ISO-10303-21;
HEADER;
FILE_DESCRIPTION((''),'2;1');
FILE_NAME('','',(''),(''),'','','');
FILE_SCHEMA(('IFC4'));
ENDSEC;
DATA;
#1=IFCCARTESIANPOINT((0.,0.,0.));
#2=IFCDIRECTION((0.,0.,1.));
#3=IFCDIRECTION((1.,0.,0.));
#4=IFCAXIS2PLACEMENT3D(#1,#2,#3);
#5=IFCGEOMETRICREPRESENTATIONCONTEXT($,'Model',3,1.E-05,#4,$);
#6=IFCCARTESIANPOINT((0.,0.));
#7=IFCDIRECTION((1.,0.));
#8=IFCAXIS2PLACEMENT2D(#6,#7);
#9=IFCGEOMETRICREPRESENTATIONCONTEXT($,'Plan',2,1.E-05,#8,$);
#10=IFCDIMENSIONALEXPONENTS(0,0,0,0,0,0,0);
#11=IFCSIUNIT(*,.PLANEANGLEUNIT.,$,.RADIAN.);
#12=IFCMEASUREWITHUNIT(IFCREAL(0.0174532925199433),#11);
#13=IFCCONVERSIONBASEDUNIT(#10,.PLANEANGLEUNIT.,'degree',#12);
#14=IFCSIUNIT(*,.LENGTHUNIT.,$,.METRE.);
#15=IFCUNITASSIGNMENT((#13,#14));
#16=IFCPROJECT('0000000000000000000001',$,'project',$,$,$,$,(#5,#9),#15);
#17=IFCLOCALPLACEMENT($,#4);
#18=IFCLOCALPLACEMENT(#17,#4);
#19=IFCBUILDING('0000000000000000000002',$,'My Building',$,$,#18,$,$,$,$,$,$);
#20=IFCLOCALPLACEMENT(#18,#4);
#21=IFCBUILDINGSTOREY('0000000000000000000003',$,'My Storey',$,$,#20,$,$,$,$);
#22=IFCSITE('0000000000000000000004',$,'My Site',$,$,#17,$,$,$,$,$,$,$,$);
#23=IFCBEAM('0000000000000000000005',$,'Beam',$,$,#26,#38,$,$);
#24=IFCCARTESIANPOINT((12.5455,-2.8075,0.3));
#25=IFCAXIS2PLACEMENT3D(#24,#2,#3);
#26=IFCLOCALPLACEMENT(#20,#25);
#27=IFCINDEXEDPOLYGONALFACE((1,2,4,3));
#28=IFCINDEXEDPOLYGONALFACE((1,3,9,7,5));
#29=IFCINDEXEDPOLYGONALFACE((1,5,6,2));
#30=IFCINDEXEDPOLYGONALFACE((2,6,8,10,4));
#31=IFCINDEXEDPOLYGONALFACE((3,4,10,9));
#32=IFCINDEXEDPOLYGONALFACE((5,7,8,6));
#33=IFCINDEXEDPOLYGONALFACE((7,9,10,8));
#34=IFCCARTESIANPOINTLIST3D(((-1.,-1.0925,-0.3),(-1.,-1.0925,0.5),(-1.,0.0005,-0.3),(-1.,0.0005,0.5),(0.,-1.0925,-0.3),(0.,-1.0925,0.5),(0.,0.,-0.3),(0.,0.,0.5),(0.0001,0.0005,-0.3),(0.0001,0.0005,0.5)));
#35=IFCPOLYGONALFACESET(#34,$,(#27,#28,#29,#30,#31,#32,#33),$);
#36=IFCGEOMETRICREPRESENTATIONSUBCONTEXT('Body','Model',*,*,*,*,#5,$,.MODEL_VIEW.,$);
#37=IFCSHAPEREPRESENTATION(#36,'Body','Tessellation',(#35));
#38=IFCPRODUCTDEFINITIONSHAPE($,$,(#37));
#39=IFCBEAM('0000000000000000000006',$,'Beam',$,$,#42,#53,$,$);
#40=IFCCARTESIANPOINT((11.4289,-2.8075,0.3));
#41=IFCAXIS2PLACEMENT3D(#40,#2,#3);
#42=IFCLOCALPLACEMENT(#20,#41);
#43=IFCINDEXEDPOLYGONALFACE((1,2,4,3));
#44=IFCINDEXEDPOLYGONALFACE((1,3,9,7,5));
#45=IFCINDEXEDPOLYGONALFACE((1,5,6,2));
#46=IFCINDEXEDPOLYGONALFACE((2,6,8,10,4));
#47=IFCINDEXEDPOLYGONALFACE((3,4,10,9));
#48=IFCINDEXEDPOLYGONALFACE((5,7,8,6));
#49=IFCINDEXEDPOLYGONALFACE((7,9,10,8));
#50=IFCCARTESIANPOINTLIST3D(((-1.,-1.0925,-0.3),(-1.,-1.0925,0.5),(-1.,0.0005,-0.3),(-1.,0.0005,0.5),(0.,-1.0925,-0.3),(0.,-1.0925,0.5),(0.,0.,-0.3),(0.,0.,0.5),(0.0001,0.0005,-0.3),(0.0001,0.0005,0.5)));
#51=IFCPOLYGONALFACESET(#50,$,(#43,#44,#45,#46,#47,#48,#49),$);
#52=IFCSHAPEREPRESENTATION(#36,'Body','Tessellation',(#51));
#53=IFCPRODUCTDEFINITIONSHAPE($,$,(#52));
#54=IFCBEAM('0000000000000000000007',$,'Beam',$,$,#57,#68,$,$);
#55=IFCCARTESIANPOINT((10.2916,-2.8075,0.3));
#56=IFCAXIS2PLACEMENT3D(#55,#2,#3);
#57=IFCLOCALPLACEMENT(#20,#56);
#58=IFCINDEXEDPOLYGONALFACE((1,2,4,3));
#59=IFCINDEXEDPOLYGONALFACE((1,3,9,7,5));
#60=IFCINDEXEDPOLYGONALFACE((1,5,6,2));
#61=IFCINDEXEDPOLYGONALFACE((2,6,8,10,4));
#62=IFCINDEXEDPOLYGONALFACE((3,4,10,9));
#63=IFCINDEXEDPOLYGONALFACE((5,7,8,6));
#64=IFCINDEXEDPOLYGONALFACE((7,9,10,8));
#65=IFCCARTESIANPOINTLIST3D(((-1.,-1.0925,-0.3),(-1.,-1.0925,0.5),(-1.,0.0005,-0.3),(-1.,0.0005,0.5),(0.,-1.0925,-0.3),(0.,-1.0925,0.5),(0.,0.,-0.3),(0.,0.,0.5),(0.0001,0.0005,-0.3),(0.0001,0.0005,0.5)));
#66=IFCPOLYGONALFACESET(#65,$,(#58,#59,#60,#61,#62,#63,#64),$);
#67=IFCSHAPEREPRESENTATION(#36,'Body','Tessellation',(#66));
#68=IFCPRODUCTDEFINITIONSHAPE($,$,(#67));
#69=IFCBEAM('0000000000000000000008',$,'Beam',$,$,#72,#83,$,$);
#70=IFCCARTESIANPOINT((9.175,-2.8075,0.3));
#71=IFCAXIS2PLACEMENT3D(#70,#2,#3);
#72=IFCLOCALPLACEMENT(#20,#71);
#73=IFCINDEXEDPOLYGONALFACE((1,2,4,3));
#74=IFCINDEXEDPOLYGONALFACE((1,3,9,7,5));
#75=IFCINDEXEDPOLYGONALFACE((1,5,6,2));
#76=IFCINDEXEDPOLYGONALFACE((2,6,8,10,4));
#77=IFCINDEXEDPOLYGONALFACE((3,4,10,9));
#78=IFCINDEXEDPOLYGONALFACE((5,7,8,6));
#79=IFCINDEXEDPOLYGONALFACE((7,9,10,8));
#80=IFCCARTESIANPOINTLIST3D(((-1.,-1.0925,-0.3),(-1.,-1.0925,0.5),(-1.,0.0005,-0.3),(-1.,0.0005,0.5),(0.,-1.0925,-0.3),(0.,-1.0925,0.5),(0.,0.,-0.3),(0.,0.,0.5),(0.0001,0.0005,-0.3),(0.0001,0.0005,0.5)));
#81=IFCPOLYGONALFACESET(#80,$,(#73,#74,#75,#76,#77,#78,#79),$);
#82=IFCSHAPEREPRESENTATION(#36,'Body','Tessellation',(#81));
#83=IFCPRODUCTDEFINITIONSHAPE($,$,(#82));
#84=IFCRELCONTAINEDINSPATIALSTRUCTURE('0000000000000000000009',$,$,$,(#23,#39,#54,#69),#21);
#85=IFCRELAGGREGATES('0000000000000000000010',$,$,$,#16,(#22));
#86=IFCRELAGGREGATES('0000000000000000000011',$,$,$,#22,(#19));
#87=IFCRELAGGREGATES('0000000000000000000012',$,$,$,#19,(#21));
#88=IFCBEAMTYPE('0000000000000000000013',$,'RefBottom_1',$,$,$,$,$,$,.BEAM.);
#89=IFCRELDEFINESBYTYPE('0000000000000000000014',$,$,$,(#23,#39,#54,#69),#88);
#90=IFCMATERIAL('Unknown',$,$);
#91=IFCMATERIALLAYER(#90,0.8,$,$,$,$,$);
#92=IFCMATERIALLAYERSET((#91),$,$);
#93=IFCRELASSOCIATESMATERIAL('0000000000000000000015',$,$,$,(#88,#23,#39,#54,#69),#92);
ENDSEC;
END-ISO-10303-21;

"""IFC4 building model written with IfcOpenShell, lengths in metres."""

from ifc_helpers import new_model, entity, si_unit, converted_unit, frame, origin_with_axes, origin_2d_with_axis, place, context, subcontext, project, spatial, indexed_curve, outline, extrude, material, layer, layer_set, layer_usage, type_object, element, save


model = new_model("IFC4")

# Units and contexts
model_context = context("Model", 3, precision=1e-05, world=origin_with_axes())
plan_context = context("Plan", 2, precision=1e-05, world=origin_2d_with_axis())
body_context_1 = subcontext(model_context, "Body", "Model", "MODEL_VIEW")
ifc_project = project(units=[converted_unit("PLANEANGLEUNIT", "degree", entity("IfcReal", 0.0174532925199433), si_unit("PLANEANGLEUNIT", "RADIAN"), dimensions=[0, 0, 0, 0, 0, 0, 0]), si_unit("LENGTHUNIT", "METRE")], contexts=[model_context, plan_context])

# Site, building, storey
site_placement = place(None, origin_with_axes())
site = spatial("IfcSite", under=ifc_project, at=site_placement, Name="My Site")
building_placement = place(site_placement, origin_with_axes())
building = spatial("IfcBuilding", under=site, at=building_placement, Name="My Building")
storey_placement = place(building_placement, origin_with_axes())
storey = spatial("IfcBuildingStorey", under=building, at=storey_placement, Name="My Storey")

# Shared definitions
ifc_material = material(Name="Unknown")

# Beams
ifc_layer_1 = layer(ifc_material, 0.8)
ifc_layer_set_1 = layer_set([ifc_layer_1])
ifc_layer_usage_1 = layer_usage(ifc_layer_set_1, "AXIS3", "POSITIVE", -0.3)
beam_type_1 = type_object("IfcBeamType", Name="RefBottom_1", PredefinedType="BEAM", material=ifc_layer_set_1)
beam_1_placement = place(storey_placement, frame((12.5455, -2.8075, 0.3), z_axis=(0.0, 0.0, 1.0), x_axis=(1.0, 0.0, 0.0)))
element("IfcBeam", 1, at=beam_1_placement, inside=storey, type_object=beam_type_1, material=ifc_layer_usage_1, Name="Beam", context=body_context_1, shape_type="SweptSolid", body=[
    extrude(outline(indexed_curve([(0.0, 0.0), (0.0, -1.0925), (-1.0, -1.0925), (-1.0, 0.0005), (0.0001, 0.0005), (0.0, 0.0)])), frame((0.0, 0.0, -0.3), z_axis=(0.0, 0.0, 1.0), x_axis=(1.0, 0.0, 0.0)), (0.0, 0.0, 1.0), 0.8),
])
ifc_layer_usage_2 = layer_usage(ifc_layer_set_1, "AXIS3", "POSITIVE", -0.3)
beam_2_placement = place(storey_placement, frame((11.4289, -2.8075, 0.3), z_axis=(0.0, 0.0, 1.0), x_axis=(1.0, 0.0, 0.0)))
element("IfcBeam", 2, at=beam_2_placement, inside=storey, type_object=beam_type_1, material=ifc_layer_usage_2, Name="Beam", context=body_context_1, shape_type="SweptSolid", body=[
    extrude(outline(indexed_curve([(0.0, 0.0), (0.0, -1.0925), (-1.0, -1.0925), (-1.0, 0.0005), (0.0001, 0.0005), (0.0, 0.0)])), frame((0.0, 0.0, -0.3), z_axis=(0.0, 0.0, 1.0), x_axis=(1.0, 0.0, 0.0)), (0.0, 0.0, 1.0), 0.8),
])
ifc_layer_usage_3 = layer_usage(ifc_layer_set_1, "AXIS3", "POSITIVE", -0.3)
beam_3_placement = place(storey_placement, frame((10.2916, -2.8075, 0.3), z_axis=(0.0, 0.0, 1.0), x_axis=(1.0, 0.0, 0.0)))
element("IfcBeam", 3, at=beam_3_placement, inside=storey, type_object=beam_type_1, material=ifc_layer_usage_3, Name="Beam", context=body_context_1, shape_type="SweptSolid", body=[
    extrude(outline(indexed_curve([(0.0, 0.0), (0.0, -1.0925), (-1.0, -1.0925), (-1.0, 0.0005), (0.0001, 0.0005), (0.0, 0.0)])), frame((0.0, 0.0, -0.3), z_axis=(0.0, 0.0, 1.0), x_axis=(1.0, 0.0, 0.0)), (0.0, 0.0, 1.0), 0.8),
])
ifc_layer_usage_4 = layer_usage(ifc_layer_set_1, "AXIS3", "POSITIVE", -0.3)
beam_4_placement = place(storey_placement, frame((9.175, -2.8075, 0.3), z_axis=(0.0, 0.0, 1.0), x_axis=(1.0, 0.0, 0.0)))
element("IfcBeam", 4, at=beam_4_placement, inside=storey, type_object=beam_type_1, material=ifc_layer_usage_4, Name="Beam", context=body_context_1, shape_type="SweptSolid", body=[
    extrude(outline(indexed_curve([(0.0, 0.0), (0.0, -1.0925), (-1.0, -1.0925), (-1.0, 0.0005), (0.0001, 0.0005), (0.0, 0.0)])), frame((0.0, 0.0, -0.3), z_axis=(0.0, 0.0, 1.0), x_axis=(1.0, 0.0, 0.0)), (0.0, 0.0, 1.0), 0.8),
])

save(model, "model.ifc")
